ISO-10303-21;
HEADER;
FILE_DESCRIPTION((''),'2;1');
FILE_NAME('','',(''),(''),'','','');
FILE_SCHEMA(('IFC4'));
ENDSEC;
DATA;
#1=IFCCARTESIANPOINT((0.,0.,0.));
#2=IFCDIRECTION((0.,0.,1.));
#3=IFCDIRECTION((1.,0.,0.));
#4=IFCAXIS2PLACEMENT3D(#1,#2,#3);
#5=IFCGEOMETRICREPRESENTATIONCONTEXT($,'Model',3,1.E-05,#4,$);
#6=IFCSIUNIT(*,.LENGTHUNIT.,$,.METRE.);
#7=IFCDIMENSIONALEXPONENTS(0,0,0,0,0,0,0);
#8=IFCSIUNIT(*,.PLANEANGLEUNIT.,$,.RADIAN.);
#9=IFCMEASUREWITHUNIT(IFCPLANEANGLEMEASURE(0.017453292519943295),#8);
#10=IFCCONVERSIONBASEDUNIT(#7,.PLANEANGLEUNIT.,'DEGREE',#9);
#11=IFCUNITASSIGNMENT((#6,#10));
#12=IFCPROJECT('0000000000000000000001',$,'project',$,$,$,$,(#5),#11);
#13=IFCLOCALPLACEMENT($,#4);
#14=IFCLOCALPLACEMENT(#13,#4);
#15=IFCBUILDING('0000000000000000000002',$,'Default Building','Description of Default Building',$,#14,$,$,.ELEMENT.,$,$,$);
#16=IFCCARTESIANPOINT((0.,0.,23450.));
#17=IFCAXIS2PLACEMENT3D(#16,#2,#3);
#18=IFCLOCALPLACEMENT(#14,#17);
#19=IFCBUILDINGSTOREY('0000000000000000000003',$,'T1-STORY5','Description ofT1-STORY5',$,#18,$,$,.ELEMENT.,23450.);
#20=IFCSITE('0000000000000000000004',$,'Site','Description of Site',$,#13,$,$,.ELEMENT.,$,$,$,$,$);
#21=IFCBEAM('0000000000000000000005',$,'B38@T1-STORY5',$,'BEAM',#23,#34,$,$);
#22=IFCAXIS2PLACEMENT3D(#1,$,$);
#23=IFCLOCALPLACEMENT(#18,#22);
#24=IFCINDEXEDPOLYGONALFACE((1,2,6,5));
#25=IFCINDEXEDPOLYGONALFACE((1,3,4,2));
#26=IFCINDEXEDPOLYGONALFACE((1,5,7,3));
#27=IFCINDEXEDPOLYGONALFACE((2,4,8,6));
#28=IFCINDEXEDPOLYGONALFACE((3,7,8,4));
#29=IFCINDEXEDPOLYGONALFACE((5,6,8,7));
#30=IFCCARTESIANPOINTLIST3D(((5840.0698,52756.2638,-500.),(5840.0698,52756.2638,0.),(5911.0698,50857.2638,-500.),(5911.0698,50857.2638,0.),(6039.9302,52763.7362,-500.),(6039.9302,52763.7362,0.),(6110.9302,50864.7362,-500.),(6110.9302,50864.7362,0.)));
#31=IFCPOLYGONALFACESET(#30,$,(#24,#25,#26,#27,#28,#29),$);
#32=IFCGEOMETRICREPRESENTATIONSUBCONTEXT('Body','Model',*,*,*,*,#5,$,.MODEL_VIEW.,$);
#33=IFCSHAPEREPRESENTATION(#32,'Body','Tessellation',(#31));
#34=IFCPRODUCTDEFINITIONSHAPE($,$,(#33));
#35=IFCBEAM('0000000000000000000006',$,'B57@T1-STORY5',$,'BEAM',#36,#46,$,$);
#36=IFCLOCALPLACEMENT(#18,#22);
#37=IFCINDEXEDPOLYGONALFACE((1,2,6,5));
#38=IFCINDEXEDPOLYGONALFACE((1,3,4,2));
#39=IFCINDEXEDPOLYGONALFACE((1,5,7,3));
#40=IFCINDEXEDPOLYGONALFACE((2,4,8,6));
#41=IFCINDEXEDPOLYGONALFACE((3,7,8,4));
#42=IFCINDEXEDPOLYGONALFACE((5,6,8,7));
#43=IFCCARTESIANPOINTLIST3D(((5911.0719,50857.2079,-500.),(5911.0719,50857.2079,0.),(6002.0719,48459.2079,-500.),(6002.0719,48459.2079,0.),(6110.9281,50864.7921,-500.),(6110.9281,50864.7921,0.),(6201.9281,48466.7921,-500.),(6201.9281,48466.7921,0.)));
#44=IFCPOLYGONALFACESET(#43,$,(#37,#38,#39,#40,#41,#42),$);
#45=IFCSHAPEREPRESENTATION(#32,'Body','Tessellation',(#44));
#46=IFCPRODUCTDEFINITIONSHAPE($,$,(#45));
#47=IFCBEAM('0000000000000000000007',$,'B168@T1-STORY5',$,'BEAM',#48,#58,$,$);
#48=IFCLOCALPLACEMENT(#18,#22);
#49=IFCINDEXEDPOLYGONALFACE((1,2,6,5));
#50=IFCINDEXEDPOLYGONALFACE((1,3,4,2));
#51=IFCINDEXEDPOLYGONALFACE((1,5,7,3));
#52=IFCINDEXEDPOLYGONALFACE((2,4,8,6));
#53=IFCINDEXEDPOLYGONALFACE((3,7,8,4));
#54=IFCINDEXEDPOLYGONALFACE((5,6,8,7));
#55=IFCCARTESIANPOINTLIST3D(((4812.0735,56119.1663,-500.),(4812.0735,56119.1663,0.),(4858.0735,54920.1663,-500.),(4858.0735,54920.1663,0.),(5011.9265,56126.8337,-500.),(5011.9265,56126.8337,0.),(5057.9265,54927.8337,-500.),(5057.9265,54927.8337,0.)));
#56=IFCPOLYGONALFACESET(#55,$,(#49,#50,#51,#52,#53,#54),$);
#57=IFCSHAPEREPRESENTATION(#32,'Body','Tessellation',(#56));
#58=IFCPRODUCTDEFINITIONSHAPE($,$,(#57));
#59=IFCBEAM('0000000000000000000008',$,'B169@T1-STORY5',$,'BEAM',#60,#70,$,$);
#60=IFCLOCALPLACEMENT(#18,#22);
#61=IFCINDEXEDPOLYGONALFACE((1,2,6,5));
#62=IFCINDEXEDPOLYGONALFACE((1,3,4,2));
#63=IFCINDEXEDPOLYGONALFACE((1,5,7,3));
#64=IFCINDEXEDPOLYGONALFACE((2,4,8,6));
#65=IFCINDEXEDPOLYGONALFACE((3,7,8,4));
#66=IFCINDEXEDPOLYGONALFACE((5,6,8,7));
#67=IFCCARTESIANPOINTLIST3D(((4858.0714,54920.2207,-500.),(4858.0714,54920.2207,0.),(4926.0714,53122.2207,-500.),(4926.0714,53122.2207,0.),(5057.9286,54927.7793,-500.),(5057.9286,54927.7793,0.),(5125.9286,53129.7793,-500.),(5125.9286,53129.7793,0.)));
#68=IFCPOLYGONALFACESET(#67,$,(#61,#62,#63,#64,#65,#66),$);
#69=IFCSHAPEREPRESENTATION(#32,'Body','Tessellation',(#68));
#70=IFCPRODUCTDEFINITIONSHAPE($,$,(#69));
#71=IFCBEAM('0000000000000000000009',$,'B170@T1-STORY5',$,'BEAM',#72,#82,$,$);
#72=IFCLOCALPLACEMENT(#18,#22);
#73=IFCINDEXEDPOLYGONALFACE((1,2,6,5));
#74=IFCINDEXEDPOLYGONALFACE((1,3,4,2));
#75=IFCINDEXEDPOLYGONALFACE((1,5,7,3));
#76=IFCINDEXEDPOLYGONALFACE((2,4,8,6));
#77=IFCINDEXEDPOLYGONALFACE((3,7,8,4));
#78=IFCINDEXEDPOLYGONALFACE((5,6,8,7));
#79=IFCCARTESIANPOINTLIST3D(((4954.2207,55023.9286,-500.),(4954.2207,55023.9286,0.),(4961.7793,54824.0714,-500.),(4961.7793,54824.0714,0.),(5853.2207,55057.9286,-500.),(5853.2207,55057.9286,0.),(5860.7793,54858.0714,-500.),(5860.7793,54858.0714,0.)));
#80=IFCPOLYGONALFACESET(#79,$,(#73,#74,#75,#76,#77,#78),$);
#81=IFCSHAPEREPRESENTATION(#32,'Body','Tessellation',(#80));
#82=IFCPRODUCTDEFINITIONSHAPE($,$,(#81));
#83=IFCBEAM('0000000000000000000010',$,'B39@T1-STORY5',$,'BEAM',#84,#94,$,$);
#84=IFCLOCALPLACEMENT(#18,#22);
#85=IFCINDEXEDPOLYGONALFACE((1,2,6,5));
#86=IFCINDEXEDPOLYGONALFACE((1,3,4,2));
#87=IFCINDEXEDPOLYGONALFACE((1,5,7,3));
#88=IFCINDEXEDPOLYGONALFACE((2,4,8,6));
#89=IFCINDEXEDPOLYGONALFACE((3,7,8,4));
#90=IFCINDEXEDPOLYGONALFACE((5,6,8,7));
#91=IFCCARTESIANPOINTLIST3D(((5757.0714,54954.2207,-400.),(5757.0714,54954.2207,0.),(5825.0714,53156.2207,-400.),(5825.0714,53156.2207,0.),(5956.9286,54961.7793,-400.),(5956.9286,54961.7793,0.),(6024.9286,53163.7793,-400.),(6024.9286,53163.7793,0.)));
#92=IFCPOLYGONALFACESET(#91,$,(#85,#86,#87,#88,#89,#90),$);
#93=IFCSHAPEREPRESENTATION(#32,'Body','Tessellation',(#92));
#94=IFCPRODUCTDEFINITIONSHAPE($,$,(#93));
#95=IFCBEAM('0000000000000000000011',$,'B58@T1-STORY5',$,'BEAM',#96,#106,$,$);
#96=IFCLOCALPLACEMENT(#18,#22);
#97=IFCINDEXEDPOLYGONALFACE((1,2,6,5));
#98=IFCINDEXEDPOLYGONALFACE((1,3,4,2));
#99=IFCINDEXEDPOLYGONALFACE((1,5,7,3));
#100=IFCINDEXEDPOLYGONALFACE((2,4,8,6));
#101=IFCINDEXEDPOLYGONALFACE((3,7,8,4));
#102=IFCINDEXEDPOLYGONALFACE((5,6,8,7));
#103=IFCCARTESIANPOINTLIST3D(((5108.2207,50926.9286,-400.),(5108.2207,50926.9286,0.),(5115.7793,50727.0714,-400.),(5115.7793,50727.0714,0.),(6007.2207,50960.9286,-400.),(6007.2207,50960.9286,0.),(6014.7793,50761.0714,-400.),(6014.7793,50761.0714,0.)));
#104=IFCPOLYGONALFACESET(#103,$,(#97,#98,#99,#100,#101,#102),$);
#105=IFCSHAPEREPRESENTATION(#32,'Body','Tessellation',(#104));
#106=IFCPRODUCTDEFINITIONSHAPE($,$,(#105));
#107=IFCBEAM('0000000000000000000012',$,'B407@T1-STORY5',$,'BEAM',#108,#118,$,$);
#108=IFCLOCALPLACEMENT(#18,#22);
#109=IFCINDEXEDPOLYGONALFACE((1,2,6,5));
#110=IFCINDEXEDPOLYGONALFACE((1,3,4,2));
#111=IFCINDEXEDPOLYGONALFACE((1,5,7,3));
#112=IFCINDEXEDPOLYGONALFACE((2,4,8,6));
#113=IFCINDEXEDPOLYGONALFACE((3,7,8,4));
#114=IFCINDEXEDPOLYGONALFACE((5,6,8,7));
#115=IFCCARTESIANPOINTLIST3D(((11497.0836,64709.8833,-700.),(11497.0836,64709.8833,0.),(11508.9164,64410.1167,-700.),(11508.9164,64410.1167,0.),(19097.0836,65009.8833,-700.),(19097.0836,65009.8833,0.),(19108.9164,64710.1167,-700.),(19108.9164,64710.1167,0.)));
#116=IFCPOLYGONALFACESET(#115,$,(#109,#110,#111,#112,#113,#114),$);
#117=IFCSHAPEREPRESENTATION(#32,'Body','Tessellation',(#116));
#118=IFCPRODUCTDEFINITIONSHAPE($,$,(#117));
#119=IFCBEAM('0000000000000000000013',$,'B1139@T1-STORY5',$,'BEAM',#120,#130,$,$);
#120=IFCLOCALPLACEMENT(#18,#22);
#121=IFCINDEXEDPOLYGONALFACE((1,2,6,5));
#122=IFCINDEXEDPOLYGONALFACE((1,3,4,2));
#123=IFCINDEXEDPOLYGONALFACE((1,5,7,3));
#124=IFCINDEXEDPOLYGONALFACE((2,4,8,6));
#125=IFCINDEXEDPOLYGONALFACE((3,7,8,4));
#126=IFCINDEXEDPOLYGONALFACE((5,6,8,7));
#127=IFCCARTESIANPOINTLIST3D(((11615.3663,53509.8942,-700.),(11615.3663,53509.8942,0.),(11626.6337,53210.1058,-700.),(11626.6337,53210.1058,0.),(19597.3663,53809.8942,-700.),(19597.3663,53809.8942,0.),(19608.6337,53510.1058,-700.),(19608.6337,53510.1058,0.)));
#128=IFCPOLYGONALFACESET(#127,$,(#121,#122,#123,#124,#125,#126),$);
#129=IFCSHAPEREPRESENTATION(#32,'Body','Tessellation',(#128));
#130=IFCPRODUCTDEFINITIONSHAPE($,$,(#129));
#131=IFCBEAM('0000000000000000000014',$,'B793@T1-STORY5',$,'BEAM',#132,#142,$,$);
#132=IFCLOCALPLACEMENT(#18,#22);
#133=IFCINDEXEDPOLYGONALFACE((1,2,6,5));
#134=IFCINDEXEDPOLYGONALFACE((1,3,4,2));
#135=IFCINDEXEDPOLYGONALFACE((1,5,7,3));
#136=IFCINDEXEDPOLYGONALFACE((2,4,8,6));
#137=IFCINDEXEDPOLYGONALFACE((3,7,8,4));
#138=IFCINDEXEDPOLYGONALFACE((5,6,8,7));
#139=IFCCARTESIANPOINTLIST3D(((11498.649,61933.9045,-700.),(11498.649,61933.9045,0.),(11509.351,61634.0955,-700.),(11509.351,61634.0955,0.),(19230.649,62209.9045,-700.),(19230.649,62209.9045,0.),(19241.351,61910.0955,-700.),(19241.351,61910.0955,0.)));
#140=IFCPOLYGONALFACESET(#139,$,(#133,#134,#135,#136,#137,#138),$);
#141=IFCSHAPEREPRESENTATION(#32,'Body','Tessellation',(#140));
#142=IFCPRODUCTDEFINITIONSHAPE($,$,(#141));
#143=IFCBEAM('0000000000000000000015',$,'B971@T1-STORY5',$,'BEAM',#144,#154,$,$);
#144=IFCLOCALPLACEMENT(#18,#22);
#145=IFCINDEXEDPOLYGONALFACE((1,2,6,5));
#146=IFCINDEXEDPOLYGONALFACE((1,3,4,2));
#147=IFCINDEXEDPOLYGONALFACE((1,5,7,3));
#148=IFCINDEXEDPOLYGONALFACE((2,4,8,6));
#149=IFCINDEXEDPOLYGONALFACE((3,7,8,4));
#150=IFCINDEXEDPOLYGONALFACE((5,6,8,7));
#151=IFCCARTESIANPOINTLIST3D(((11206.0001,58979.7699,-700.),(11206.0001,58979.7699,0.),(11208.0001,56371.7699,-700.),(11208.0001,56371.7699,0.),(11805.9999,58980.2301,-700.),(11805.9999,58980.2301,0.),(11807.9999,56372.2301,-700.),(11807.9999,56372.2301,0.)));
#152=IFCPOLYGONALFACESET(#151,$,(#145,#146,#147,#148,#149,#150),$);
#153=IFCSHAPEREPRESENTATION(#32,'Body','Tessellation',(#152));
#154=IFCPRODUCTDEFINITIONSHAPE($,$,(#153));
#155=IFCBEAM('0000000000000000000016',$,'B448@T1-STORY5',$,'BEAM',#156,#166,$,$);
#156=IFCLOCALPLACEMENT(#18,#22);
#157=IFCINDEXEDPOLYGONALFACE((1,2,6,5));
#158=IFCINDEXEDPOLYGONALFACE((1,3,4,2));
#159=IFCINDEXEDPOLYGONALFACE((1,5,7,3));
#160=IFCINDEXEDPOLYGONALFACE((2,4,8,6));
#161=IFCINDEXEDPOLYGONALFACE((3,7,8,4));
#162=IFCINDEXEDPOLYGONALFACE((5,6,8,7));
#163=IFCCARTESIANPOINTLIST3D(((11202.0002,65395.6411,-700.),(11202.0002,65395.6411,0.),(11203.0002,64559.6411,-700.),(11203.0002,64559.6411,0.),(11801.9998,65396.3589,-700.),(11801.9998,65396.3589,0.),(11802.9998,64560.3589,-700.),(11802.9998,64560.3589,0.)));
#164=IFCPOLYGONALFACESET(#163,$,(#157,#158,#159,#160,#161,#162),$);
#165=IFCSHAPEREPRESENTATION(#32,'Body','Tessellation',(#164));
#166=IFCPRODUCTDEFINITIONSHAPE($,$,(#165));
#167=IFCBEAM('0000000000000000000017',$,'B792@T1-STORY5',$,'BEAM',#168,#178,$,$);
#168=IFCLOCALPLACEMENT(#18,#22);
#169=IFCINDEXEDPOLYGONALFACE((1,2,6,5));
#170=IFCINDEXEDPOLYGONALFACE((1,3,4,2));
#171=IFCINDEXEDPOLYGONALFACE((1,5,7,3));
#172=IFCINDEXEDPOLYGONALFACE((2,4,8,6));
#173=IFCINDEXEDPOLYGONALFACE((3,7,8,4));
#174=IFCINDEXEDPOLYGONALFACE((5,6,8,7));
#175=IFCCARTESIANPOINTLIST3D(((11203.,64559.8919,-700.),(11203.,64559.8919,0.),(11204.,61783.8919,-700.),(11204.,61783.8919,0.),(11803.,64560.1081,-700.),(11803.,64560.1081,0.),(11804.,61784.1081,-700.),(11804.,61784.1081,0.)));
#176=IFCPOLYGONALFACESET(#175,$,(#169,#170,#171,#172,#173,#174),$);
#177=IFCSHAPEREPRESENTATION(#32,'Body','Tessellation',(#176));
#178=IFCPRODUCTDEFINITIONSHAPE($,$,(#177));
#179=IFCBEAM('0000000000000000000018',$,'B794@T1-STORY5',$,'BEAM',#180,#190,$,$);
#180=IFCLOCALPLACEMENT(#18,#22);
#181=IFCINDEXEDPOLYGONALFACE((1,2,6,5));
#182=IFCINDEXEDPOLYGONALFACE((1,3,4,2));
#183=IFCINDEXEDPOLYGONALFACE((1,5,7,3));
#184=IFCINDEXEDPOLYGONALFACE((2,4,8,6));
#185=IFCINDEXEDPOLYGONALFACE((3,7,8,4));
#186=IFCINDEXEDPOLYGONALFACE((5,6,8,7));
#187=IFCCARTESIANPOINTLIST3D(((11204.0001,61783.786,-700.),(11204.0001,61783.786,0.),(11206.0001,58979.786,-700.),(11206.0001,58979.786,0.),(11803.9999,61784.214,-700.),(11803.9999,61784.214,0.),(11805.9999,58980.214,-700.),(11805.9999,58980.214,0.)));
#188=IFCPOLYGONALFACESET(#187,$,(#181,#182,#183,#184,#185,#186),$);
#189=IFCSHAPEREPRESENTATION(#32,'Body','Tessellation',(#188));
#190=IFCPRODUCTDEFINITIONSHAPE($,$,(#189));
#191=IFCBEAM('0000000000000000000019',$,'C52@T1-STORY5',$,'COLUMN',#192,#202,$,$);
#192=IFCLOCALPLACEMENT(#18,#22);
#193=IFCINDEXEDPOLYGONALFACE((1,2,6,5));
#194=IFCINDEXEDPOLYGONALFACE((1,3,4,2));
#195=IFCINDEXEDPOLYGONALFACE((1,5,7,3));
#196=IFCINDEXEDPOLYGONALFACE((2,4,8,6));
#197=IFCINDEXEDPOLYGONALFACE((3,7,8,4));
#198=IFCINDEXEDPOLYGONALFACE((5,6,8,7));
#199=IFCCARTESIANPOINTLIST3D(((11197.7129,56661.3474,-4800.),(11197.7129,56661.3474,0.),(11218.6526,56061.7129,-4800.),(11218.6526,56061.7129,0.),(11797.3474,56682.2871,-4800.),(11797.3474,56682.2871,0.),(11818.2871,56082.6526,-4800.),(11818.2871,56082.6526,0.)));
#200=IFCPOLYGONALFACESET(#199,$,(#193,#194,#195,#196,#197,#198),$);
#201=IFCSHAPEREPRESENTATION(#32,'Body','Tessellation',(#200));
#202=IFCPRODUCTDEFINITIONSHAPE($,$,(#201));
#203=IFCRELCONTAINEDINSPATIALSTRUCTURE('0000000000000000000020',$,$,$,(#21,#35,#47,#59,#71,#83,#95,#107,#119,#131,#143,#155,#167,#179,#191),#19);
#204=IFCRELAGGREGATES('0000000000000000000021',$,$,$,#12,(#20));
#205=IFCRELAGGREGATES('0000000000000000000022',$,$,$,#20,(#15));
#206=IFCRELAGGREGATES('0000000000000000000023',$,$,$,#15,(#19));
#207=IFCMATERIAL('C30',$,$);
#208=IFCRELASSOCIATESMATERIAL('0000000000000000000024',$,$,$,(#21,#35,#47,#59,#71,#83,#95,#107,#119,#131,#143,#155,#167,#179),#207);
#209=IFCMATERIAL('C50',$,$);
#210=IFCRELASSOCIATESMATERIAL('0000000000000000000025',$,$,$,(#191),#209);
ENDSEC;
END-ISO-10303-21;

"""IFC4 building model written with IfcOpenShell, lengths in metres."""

from ifc_helpers import new_model, entity, si_unit, converted_unit, frame, origin_with_axes, place, context, subcontext, project, spatial, rectangle, extrude, material, element, save


model = new_model("IFC4")

# Units and contexts
model_context = context("Model", 3, precision=1e-05, world=origin_with_axes())
body_context = subcontext(model_context, "Body", "Model", "MODEL_VIEW")
ifc_project = project(units=[si_unit("LENGTHUNIT", "METRE"), converted_unit("PLANEANGLEUNIT", "DEGREE", entity("IfcPlaneAngleMeasure", 0.017453292519943295), si_unit("PLANEANGLEUNIT", "RADIAN"), dimensions=[0, 0, 0, 0, 0, 0, 0])], contexts=[model_context])

# Site, building, storey
site_placement = place(None, origin_with_axes())
site = spatial("IfcSite", under=ifc_project, at=site_placement, Name="Site", Description="Description of Site", CompositionType="ELEMENT")
building_placement = place(site_placement, origin_with_axes())
building = spatial("IfcBuilding", under=site, at=building_placement, Name="Default Building", Description="Description of Default Building", CompositionType="ELEMENT")
storey_placement = place(building_placement, frame((0.0, 0.0, 23450.0), z_axis=(0.0, 0.0, 1.0), x_axis=(1.0, 0.0, 0.0)))
storey = spatial("IfcBuildingStorey", under=building, at=storey_placement, Name="T1-STORY5", Description="Description ofT1-STORY5", CompositionType="ELEMENT", Elevation=23450.0)

# Beams
ifc_material_1 = material(Name="C30")
beam_1_placement = place(storey_placement, frame((5940.0, 52760.0, -250.0), z_axis=(0.037362, -0.999302, 0.0), x_axis=(0.999302, 0.037362, 0.0)))
element("IfcBeam", 1, at=beam_1_placement, inside=storey, material=ifc_material_1, Name="B38@T1-STORY5", ObjectType="BEAM", context=body_context, shape_type="SweptSolid", body=[
    extrude(rectangle(XDim=200.0, YDim=500.0), origin_with_axes(), (0.0, 0.0, 1.0), 1900.3268),
])
beam_2_placement = place(storey_placement, frame((6011.0, 50861.0, -250.0), z_axis=(0.037921, -0.999281, 0.0), x_axis=(0.999281, 0.037921, 0.0)))
element("IfcBeam", 2, at=beam_2_placement, inside=storey, material=ifc_material_1, Name="B57@T1-STORY5", ObjectType="BEAM", context=body_context, shape_type="SweptSolid", body=[
    extrude(rectangle(XDim=200.0, YDim=500.0), origin_with_axes(), (0.0, 0.0, 1.0), 2399.726),
])
beam_3_placement = place(storey_placement, frame((4912.0, 56123.0, -250.0), z_axis=(0.038337, -0.999265, 0.0), x_axis=(0.999265, 0.038337, 0.0)))
element("IfcBeam", 3, at=beam_3_placement, inside=storey, material=ifc_material_1, Name="B168@T1-STORY5", ObjectType="BEAM", context=body_context, shape_type="SweptSolid", body=[
    extrude(rectangle(XDim=200.0, YDim=500.0), origin_with_axes(), (0.0, 0.0, 1.0), 1199.8821),
])
beam_4_placement = place(storey_placement, frame((4958.0, 54924.0, -250.0), z_axis=(0.037793, -0.999286, 0.0), x_axis=(0.999286, 0.037793, 0.0)))
element("IfcBeam", 4, at=beam_4_placement, inside=storey, material=ifc_material_1, Name="B169@T1-STORY5", ObjectType="BEAM", context=body_context, shape_type="SweptSolid", body=[
    extrude(rectangle(XDim=200.0, YDim=500.0), origin_with_axes(), (0.0, 0.0, 1.0), 1799.2854),
])
beam_5_placement = place(storey_placement, frame((4958.0, 54924.0, -250.0), z_axis=(0.999286, 0.037793, 0.0), x_axis=(-0.037793, 0.999286, 0.0)))
element("IfcBeam", 5, at=beam_5_placement, inside=storey, material=ifc_material_1, Name="B170@T1-STORY5", ObjectType="BEAM", context=body_context, shape_type="SweptSolid", body=[
    extrude(rectangle(XDim=200.0, YDim=500.0), origin_with_axes(), (0.0, 0.0, 1.0), 899.6427),
])
beam_6_placement = place(storey_placement, frame((5857.0, 54958.0, -200.0), z_axis=(0.037793, -0.999286, 0.0), x_axis=(0.999286, 0.037793, 0.0)))
element("IfcBeam", 6, at=beam_6_placement, inside=storey, material=ifc_material_1, Name="B39@T1-STORY5", ObjectType="BEAM", context=body_context, shape_type="SweptSolid", body=[
    extrude(rectangle(XDim=200.0, YDim=400.0), origin_with_axes(), (0.0, 0.0, 1.0), 1799.2854),
])
beam_7_placement = place(storey_placement, frame((5112.0, 50827.0, -200.0), z_axis=(0.999286, 0.037793, 0.0), x_axis=(-0.037793, 0.999286, 0.0)))
element("IfcBeam", 7, at=beam_7_placement, inside=storey, material=ifc_material_1, Name="B58@T1-STORY5", ObjectType="BEAM", context=body_context, shape_type="SweptSolid", body=[
    extrude(rectangle(XDim=200.0, YDim=400.0), origin_with_axes(), (0.0, 0.0, 1.0), 899.6427),
])
beam_8_placement = place(storey_placement, frame((11503.0, 64560.0, -350.0), z_axis=(0.999222, 0.039443, 0.0), x_axis=(-0.039443, 0.999222, 0.0)))
element("IfcBeam", 8, at=beam_8_placement, inside=storey, material=ifc_material_1, Name="B407@T1-STORY5", ObjectType="BEAM", context=body_context, shape_type="SweptSolid", body=[
    extrude(rectangle(XDim=300.0, YDim=700.0), origin_with_axes(), (0.0, 0.0, 1.0), 7605.9187),
])
beam_9_placement = place(storey_placement, frame((11621.0, 53360.0, -350.0), z_axis=(0.999294, 0.037558, 0.0), x_axis=(-0.037558, 0.999294, 0.0)))
element("IfcBeam", 9, at=beam_9_placement, inside=storey, material=ifc_material_1, Name="B1139@T1-STORY5", ObjectType="BEAM", context=body_context, shape_type="SweptSolid", body=[
    extrude(rectangle(XDim=300.0, YDim=700.0), origin_with_axes(), (0.0, 0.0, 1.0), 7987.6357),
])
beam_10_placement = place(storey_placement, frame((11504.0, 61784.0, -350.0), z_axis=(0.999364, 0.035673, 0.0), x_axis=(-0.035673, 0.999364, 0.0)))
element("IfcBeam", 10, at=beam_10_placement, inside=storey, material=ifc_material_1, Name="B793@T1-STORY5", ObjectType="BEAM", context=body_context, shape_type="SweptSolid", body=[
    extrude(rectangle(XDim=300.0, YDim=700.0), origin_with_axes(), (0.0, 0.0, 1.0), 7736.9245),
])
beam_11_placement = place(storey_placement, frame((11508.0, 56372.0, -350.0), z_axis=(-0.000767, 1.0, 0.0), x_axis=(-1.0, -0.000767, 0.0)))
element("IfcBeam", 11, at=beam_11_placement, inside=storey, material=ifc_material_1, Name="B971@T1-STORY5", ObjectType="BEAM", context=body_context, shape_type="SweptSolid", body=[
    extrude(rectangle(XDim=600.0, YDim=700.0), origin_with_axes(), (0.0, 0.0, 1.0), 2608.0008),
])
beam_12_placement = place(storey_placement, frame((11503.0, 64560.0, -350.0), z_axis=(-0.001196, 0.999999, 0.0), x_axis=(-0.999999, -0.001196, 0.0)))
element("IfcBeam", 12, at=beam_12_placement, inside=storey, material=ifc_material_1, Name="B448@T1-STORY5", ObjectType="BEAM", context=body_context, shape_type="SweptSolid", body=[
    extrude(rectangle(XDim=600.0, YDim=700.0), origin_with_axes(), (0.0, 0.0, 1.0), 836.0006),
])
beam_13_placement = place(storey_placement, frame((11504.0, 61784.0, -350.0), z_axis=(-0.00036, 1.0, 0.0), x_axis=(-1.0, -0.00036, 0.0)))
element("IfcBeam", 13, at=beam_13_placement, inside=storey, material=ifc_material_1, Name="B792@T1-STORY5", ObjectType="BEAM", context=body_context, shape_type="SweptSolid", body=[
    extrude(rectangle(XDim=600.0, YDim=700.0), origin_with_axes(), (0.0, 0.0, 1.0), 2776.0002),
])
beam_14_placement = place(storey_placement, frame((11506.0, 58980.0, -350.0), z_axis=(-0.000713, 1.0, 0.0), x_axis=(-1.0, -0.000713, 0.0)))
element("IfcBeam", 14, at=beam_14_placement, inside=storey, material=ifc_material_1, Name="B794@T1-STORY5", ObjectType="BEAM", context=body_context, shape_type="SweptSolid", body=[
    extrude(rectangle(XDim=600.0, YDim=700.0), origin_with_axes(), (0.0, 0.0, 1.0), 2804.0007),
])
ifc_material_2 = material(Name="C50")
beam_15_placement = place(storey_placement, frame((11508.0, 56372.0, -4800.0), z_axis=(0.0, 0.0, 1.0), x_axis=(-0.999391, -0.034899, 0.0)))
element("IfcBeam", 15, at=beam_15_placement, inside=storey, material=ifc_material_2, Name="C52@T1-STORY5", ObjectType="COLUMN", context=body_context, shape_type="SweptSolid", body=[
    extrude(rectangle(XDim=600.0, YDim=600.0), origin_with_axes(), (0.0, 0.0, 1.0), 4800.0),
])

save(model, "model.ifc")
